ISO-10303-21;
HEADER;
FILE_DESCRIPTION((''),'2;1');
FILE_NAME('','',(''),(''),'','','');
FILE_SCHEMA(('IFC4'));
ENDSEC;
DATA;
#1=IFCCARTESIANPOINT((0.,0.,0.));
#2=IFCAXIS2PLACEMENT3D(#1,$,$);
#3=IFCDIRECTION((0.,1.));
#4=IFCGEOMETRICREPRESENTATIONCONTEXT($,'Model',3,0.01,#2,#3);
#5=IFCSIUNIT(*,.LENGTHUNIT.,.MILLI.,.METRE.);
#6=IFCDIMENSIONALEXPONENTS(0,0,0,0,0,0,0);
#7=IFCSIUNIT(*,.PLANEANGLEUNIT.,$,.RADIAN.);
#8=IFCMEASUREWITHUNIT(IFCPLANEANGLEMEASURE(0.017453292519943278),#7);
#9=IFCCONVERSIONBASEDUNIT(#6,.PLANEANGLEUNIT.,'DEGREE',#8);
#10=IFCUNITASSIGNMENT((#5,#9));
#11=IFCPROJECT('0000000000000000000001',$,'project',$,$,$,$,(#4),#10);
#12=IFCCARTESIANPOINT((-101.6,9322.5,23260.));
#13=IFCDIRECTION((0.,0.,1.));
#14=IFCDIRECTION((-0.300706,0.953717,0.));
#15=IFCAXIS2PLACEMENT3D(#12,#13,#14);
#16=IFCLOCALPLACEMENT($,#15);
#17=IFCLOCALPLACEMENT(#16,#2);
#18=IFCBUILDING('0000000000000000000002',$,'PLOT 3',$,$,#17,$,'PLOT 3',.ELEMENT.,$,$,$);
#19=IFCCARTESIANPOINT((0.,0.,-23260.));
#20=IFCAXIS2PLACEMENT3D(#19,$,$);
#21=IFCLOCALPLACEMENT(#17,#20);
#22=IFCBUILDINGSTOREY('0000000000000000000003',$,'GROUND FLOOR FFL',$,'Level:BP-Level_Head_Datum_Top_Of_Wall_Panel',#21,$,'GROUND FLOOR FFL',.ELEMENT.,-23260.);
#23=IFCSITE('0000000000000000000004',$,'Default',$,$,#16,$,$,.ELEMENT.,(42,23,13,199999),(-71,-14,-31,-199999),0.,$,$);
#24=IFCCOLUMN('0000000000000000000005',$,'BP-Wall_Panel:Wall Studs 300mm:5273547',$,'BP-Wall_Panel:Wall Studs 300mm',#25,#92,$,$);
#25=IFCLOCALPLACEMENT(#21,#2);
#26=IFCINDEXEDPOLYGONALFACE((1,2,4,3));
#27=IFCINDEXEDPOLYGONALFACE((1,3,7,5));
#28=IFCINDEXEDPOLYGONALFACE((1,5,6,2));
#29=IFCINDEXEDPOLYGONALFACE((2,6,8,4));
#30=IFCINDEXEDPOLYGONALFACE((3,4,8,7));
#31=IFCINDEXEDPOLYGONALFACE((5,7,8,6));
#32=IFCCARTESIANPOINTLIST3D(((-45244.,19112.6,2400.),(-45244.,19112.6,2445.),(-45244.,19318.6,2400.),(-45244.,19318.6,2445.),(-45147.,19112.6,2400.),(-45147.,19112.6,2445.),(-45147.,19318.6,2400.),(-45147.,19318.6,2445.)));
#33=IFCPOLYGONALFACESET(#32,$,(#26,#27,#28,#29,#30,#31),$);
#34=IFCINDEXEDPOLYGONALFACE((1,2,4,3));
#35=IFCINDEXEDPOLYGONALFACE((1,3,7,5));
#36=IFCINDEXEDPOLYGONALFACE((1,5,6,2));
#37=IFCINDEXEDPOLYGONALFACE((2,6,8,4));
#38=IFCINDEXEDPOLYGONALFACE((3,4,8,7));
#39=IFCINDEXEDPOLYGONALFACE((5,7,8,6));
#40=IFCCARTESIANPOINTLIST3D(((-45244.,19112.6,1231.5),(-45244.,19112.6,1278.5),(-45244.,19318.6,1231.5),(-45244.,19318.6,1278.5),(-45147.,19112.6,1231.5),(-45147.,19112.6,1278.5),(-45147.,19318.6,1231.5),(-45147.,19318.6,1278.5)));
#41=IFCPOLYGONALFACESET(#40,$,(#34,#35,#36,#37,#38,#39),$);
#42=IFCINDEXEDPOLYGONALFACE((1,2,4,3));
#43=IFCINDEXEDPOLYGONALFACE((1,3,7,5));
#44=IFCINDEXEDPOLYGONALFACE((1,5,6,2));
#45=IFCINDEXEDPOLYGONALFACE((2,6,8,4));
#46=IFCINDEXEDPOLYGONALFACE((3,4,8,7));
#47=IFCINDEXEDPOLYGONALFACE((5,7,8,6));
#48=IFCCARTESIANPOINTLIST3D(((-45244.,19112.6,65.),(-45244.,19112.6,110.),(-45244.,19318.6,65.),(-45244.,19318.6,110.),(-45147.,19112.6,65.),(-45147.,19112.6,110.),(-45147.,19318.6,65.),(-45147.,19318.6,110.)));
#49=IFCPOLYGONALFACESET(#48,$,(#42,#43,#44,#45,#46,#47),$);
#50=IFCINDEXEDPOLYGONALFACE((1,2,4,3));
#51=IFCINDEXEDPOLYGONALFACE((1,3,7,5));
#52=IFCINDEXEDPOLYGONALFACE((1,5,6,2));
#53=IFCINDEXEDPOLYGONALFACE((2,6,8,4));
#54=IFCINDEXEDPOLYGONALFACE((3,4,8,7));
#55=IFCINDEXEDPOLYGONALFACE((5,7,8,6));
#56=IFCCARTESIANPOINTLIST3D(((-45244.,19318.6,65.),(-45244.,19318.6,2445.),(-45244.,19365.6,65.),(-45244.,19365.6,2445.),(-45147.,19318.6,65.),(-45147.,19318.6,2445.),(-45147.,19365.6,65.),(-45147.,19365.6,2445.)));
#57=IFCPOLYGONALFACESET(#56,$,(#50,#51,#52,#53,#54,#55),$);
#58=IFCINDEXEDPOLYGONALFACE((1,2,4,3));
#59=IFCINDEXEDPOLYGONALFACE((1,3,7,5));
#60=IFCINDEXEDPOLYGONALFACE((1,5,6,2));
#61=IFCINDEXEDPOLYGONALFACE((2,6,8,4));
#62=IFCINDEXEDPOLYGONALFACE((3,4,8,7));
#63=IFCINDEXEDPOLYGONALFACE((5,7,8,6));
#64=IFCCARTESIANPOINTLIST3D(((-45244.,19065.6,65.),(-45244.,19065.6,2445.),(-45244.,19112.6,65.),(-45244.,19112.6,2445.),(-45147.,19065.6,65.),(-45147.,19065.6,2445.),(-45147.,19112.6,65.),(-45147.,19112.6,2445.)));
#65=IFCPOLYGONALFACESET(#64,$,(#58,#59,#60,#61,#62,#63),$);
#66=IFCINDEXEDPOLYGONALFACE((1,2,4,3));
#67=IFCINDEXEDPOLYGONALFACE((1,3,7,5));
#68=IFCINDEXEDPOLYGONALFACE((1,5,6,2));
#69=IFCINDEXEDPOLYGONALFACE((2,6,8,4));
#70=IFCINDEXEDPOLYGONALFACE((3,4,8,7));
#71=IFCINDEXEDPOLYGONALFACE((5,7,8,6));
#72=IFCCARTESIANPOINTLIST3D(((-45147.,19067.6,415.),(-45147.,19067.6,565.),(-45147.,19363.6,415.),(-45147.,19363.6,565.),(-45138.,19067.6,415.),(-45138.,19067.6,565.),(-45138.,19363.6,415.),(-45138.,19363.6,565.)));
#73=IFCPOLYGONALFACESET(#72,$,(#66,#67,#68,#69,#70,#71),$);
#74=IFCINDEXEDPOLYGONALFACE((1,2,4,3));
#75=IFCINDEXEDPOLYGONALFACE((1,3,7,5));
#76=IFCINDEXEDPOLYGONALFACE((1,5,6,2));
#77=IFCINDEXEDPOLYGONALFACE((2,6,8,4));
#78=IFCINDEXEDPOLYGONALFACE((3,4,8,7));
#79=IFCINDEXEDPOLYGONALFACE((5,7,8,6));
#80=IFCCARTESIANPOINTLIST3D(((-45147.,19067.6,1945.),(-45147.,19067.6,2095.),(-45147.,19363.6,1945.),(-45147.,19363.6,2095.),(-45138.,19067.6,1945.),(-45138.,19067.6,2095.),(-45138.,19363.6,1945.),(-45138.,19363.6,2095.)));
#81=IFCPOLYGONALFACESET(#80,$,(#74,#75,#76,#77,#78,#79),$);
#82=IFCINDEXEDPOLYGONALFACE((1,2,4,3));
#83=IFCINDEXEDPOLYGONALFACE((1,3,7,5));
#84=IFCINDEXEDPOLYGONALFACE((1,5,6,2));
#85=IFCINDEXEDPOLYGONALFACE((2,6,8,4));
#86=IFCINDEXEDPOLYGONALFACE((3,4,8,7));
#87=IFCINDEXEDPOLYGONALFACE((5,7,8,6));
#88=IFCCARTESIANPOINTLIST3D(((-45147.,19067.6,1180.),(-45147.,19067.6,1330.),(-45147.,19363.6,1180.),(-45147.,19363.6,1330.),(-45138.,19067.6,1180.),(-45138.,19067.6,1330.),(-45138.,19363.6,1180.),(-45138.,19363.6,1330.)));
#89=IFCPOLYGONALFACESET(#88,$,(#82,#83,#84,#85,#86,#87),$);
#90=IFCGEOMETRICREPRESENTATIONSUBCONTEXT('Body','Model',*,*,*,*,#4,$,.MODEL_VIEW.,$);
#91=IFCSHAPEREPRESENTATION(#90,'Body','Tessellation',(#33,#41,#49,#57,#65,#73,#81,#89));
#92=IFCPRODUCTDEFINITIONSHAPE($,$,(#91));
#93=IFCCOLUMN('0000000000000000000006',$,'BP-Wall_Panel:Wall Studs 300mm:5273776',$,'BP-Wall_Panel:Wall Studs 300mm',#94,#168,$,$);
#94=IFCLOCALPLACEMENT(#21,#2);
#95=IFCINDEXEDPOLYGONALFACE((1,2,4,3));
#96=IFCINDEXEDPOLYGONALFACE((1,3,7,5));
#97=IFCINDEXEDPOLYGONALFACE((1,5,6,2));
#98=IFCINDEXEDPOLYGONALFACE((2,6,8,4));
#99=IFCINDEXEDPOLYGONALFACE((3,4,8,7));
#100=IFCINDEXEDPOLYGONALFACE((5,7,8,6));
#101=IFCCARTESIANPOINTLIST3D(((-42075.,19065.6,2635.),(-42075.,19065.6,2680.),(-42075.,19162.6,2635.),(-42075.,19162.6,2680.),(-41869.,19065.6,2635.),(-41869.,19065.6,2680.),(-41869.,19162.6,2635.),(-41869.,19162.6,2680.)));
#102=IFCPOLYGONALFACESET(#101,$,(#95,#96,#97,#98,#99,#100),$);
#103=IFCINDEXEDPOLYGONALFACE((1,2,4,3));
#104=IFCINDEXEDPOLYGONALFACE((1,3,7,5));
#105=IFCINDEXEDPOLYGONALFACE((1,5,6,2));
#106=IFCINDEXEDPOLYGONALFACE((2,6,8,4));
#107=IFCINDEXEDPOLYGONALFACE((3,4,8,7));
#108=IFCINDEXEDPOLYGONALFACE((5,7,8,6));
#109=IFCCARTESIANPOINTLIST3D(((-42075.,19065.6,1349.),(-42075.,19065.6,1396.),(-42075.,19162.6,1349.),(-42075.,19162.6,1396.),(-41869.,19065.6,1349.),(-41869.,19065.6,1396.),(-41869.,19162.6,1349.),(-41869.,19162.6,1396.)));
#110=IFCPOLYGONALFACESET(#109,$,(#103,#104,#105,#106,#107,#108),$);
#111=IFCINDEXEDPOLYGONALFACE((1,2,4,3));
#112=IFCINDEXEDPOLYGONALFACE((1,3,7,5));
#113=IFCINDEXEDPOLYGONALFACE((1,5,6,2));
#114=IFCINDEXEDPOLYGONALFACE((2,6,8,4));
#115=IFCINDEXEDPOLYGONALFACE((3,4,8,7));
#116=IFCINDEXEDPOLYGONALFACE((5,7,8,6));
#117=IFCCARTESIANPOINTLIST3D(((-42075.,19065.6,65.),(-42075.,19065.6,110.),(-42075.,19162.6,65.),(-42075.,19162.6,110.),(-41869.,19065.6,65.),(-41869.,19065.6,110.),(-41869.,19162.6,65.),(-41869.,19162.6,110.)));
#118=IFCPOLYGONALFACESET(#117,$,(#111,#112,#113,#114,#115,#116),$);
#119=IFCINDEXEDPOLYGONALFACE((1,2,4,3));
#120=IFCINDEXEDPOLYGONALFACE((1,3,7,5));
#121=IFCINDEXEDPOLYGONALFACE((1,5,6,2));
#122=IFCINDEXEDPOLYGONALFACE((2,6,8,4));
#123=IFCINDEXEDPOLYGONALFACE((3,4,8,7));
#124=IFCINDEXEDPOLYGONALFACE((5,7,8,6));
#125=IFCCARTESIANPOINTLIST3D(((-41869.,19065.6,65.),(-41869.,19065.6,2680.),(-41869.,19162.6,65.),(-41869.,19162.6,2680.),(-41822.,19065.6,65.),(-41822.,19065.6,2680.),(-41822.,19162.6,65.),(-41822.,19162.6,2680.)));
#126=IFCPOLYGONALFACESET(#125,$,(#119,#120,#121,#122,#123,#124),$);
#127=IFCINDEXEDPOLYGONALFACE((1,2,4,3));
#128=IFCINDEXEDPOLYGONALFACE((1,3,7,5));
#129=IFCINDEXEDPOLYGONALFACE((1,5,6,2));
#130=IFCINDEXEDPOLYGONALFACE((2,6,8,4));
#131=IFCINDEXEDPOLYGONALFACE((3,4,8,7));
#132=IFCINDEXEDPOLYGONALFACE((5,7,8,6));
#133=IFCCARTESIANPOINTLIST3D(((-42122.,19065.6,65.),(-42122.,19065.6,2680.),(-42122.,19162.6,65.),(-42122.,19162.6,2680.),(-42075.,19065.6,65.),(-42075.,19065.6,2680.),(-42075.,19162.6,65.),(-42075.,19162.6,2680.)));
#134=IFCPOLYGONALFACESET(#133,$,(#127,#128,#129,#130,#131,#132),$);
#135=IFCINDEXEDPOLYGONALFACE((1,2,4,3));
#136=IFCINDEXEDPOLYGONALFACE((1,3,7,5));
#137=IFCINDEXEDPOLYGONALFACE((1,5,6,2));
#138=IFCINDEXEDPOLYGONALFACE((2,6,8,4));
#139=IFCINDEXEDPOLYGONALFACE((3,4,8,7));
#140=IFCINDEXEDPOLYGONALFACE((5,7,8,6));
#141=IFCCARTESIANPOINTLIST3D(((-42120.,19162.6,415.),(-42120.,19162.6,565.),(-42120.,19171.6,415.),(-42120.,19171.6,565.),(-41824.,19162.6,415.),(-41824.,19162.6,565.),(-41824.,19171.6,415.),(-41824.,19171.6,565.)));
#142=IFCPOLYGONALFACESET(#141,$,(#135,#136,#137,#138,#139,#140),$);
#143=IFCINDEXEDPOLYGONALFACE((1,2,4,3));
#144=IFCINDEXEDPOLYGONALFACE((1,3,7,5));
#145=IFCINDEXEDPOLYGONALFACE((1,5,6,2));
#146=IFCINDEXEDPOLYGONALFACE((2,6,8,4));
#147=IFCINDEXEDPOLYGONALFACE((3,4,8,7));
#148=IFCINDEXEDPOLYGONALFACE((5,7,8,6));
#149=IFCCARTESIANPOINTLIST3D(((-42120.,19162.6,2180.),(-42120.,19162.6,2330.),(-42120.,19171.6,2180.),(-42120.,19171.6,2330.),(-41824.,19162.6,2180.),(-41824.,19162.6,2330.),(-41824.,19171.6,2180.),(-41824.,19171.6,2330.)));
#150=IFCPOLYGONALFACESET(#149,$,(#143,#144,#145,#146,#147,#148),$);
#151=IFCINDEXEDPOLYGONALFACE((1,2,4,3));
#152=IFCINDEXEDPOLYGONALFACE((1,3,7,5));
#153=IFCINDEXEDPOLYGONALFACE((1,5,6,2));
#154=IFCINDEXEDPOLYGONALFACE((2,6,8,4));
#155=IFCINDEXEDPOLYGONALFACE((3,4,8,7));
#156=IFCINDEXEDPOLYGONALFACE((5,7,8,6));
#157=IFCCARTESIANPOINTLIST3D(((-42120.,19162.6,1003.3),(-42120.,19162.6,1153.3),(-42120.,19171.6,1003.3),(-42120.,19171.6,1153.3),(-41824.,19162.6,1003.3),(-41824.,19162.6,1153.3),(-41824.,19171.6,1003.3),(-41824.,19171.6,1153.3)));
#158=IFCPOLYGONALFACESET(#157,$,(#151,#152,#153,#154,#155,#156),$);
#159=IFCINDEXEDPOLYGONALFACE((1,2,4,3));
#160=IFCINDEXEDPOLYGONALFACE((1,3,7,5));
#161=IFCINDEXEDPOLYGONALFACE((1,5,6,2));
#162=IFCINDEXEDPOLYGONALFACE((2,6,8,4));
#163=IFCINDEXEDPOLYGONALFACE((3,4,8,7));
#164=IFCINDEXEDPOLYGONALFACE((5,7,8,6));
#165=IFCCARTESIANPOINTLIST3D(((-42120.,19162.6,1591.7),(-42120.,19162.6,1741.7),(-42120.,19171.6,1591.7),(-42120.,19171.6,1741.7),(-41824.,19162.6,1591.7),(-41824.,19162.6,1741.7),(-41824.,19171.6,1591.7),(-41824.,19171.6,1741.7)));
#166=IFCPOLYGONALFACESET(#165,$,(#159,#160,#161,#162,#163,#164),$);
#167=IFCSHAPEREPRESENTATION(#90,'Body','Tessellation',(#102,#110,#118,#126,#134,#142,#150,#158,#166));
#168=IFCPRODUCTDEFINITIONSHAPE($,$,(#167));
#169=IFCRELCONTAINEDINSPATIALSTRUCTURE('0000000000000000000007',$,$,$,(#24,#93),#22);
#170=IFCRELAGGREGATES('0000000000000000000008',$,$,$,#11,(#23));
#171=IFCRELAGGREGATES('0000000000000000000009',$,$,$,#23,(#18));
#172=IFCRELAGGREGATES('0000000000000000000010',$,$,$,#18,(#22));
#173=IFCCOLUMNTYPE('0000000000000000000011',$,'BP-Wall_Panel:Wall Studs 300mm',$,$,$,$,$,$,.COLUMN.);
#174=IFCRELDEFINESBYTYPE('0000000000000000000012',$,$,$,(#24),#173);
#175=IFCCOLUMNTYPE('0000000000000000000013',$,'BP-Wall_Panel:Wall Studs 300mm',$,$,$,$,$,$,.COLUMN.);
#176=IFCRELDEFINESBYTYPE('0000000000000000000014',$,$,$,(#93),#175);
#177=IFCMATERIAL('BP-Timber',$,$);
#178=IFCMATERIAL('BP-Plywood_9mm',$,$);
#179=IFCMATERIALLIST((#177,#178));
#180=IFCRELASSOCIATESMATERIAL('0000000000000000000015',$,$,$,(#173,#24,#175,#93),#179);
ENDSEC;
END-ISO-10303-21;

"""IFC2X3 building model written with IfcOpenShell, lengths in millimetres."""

from ifc_helpers import new_model, entity, si_unit, converted_unit, direction, frame, frame_2d, origin, place, context, subcontext, project, spatial, rectangle, extrude, source, transform, mapped, material, material_list, type_object, type_shapes, element, save


model = new_model("IFC2X3")

# Units and contexts
model_context = context("Model", 3, precision=0.01, world=origin(), true_north=direction((0.0, 1.0)))
body_context = subcontext(model_context, "Body", "Model", "MODEL_VIEW")
ifc_project = project(units=[si_unit("LENGTHUNIT", "METRE", prefix="MILLI"), converted_unit("PLANEANGLEUNIT", "DEGREE", entity("IfcPlaneAngleMeasure", 0.017453292519943278), si_unit("PLANEANGLEUNIT", "RADIAN"), dimensions=[0, 0, 0, 0, 0, 0, 0])], contexts=[model_context])

# Site, building, storey
site_placement = place(None, frame((-101.6, 9322.5, 23260.0), z_axis=(0.0, 0.0, 1.0), x_axis=(-0.300706, 0.953717, 0.0)))
site = spatial("IfcSite", under=ifc_project, at=site_placement, Name="Default", CompositionType="ELEMENT", RefLatitude=(42, 23, 13, 199999), RefLongitude=(-71, -14, -31, -199999), RefElevation=0.0)
building_placement = place(site_placement, origin())
building = spatial("IfcBuilding", under=site, at=building_placement, Name="PLOT 3", LongName="PLOT 3", CompositionType="ELEMENT")
storey_placement = place(building_placement, frame((0.0, 0.0, -23260.0)))
storey = spatial("IfcBuildingStorey", under=building, at=storey_placement, Name="GROUND FLOOR FFL", ObjectType="Level:BP-Level_Head_Datum_Top_Of_Wall_Panel", LongName="GROUND FLOOR FFL", CompositionType="ELEMENT", Elevation=-23260.0)

# Columns
ifc_material_1 = material(Name="BP-Timber")
ifc_material_2 = material(Name="BP-Plywood_9mm")
ifc_material_list_1 = material_list([ifc_material_1, ifc_material_2])
column_type_1 = type_object("IfcColumnType", Name="BP-Wall_Panel:Wall Studs 300mm", PredefinedType="COLUMN", material=ifc_material_list_1)
shared_shape_1 = source(origin(), body_context, "Body", "SweptSolid", [
    extrude(rectangle(XDim=206.0, YDim=97.0, at=frame_2d((0.0, 0.0), x_axis=(1.0, 0.0))), frame((-45195.5, 19215.6, -20860.0), z_axis=(0.0, 0.0, 1.0), x_axis=(0.0, -1.0, 0.0)), (0.0, 0.0, 1.0), 45.0),
    extrude(rectangle(XDim=206.0, YDim=97.0, at=frame_2d((0.0, 0.0), x_axis=(1.0, 0.0))), frame((-45195.5, 19215.6, -22028.5), z_axis=(0.0, 0.0, 1.0), x_axis=(0.0, -1.0, 0.0)), (0.0, 0.0, 1.0), 47.0),
    extrude(rectangle(XDim=206.0, YDim=97.0, at=frame_2d((0.0, 0.0), x_axis=(1.0, 0.0))), frame((-45195.5, 19215.6, -23195.0), z_axis=(0.0, 0.0, 1.0), x_axis=(0.0, -1.0, 0.0)), (0.0, 0.0, 1.0), 45.0),
    extrude(rectangle(XDim=97.0, YDim=47.0, at=frame_2d((0.0, 0.0), x_axis=(1.0, 0.0))), frame((-45195.5, 19342.1, -23195.0), z_axis=(0.0, 0.0, 1.0), x_axis=(-1.0, 0.0, 0.0)), (0.0, 0.0, 1.0), 2380.0),
    extrude(rectangle(XDim=97.0, YDim=47.0, at=frame_2d((0.0, 0.0), x_axis=(1.0, 0.0))), frame((-45195.5, 19089.1, -23195.0), z_axis=(0.0, 0.0, 1.0), x_axis=(-1.0, 0.0, 0.0)), (0.0, 0.0, 1.0), 2380.0),
    extrude(rectangle(XDim=296.0, YDim=9.0, at=frame_2d((0.0, 0.0), x_axis=(1.0, 0.0))), frame((-45142.5, 19215.6, -22845.0), z_axis=(0.0, 0.0, 1.0), x_axis=(0.0, -1.0, 0.0)), (0.0, 0.0, 1.0), 150.0),
    extrude(rectangle(XDim=296.0, YDim=9.0, at=frame_2d((0.0, 0.0), x_axis=(1.0, 0.0))), frame((-45142.5, 19215.6, -21315.0), z_axis=(0.0, 0.0, 1.0), x_axis=(0.0, -1.0, 0.0)), (0.0, 0.0, 1.0), 150.0),
    extrude(rectangle(XDim=296.0, YDim=9.0, at=frame_2d((0.0, 0.0), x_axis=(1.0, 0.0))), frame((-45142.5, 19215.6, -22080.0), z_axis=(0.0, 0.0, 1.0), x_axis=(0.0, -1.0, 0.0)), (0.0, 0.0, 1.0), 150.0),
])
type_shapes(column_type_1, [shared_shape_1])
column_1_placement = place(storey_placement, frame((0.0, 0.0, 23260.0)))
element("IfcColumn", 1, at=column_1_placement, inside=storey, type_object=column_type_1, material=ifc_material_list_1, Name="BP-Wall_Panel:Wall Studs 300mm:5273547", ObjectType="BP-Wall_Panel:Wall Studs 300mm", context=body_context, shape_type="MappedRepresentation", body=[
    mapped(shared_shape_1, transform((0.0, 0.0, 0.0), scale=1.0)),
])
column_type_2 = type_object("IfcColumnType", Name="BP-Wall_Panel:Wall Studs 300mm", PredefinedType="COLUMN", material=ifc_material_list_1)
shared_shape_2 = source(origin(), body_context, "Body", "SweptSolid", [
    extrude(rectangle(XDim=97.0, YDim=206.0, at=frame_2d((0.0, 0.0), x_axis=(1.0, 0.0))), frame((-41972.0, 19114.1, -20625.0), z_axis=(0.0, 0.0, 1.0), x_axis=(0.0, 1.0, 0.0)), (0.0, 0.0, 1.0), 45.0),
    extrude(rectangle(XDim=97.0, YDim=206.0, at=frame_2d((0.0, 0.0), x_axis=(1.0, 0.0))), frame((-41972.0, 19114.1, -21911.0), z_axis=(0.0, 0.0, 1.0), x_axis=(0.0, 1.0, 0.0)), (0.0, 0.0, 1.0), 47.0),
    extrude(rectangle(XDim=97.0, YDim=206.0, at=frame_2d((0.0, 0.0), x_axis=(1.0, 0.0))), frame((-41972.0, 19114.1, -23195.0), z_axis=(0.0, 0.0, 1.0), x_axis=(0.0, 1.0, 0.0)), (0.0, 0.0, 1.0), 45.0),
    extrude(rectangle(XDim=47.0, YDim=97.0, at=frame_2d((0.0, 0.0), x_axis=(1.0, 0.0))), frame((-41845.5, 19114.1, -23195.0), z_axis=(0.0, 0.0, 1.0), x_axis=(-1.0, 0.0, 0.0)), (0.0, 0.0, 1.0), 2615.0),
    extrude(rectangle(XDim=47.0, YDim=97.0, at=frame_2d((0.0, 0.0), x_axis=(1.0, 0.0))), frame((-42098.5, 19114.1, -23195.0), z_axis=(0.0, 0.0, 1.0), x_axis=(-1.0, 0.0, 0.0)), (0.0, 0.0, 1.0), 2615.0),
    extrude(rectangle(XDim=9.0, YDim=296.0, at=frame_2d((0.0, 0.0), x_axis=(1.0, 0.0))), frame((-41972.0, 19167.1, -22845.0), z_axis=(0.0, 0.0, 1.0), x_axis=(0.0, 1.0, 0.0)), (0.0, 0.0, 1.0), 150.0),
    extrude(rectangle(XDim=9.0, YDim=296.0, at=frame_2d((0.0, 0.0), x_axis=(1.0, 0.0))), frame((-41972.0, 19167.1, -21080.0), z_axis=(0.0, 0.0, 1.0), x_axis=(0.0, 1.0, 0.0)), (0.0, 0.0, 1.0), 150.0),
    extrude(rectangle(XDim=9.0, YDim=296.0, at=frame_2d((0.0, 0.0), x_axis=(1.0, 0.0))), frame((-41972.0, 19167.1, -22256.7), z_axis=(0.0, 0.0, 1.0), x_axis=(0.0, 1.0, 0.0)), (0.0, 0.0, 1.0), 150.0),
    extrude(rectangle(XDim=9.0, YDim=296.0, at=frame_2d((0.0, 0.0), x_axis=(1.0, 0.0))), frame((-41972.0, 19167.1, -21668.3), z_axis=(0.0, 0.0, 1.0), x_axis=(0.0, 1.0, 0.0)), (0.0, 0.0, 1.0), 150.0),
])
type_shapes(column_type_2, [shared_shape_2])
column_2_placement = place(storey_placement, frame((0.0, 0.0, 23260.0)))
element("IfcColumn", 2, at=column_2_placement, inside=storey, type_object=column_type_2, material=ifc_material_list_1, Name="BP-Wall_Panel:Wall Studs 300mm:5273776", ObjectType="BP-Wall_Panel:Wall Studs 300mm", context=body_context, shape_type="MappedRepresentation", body=[
    mapped(shared_shape_2, transform((0.0, 0.0, 0.0), scale=1.0)),
])

save(model, "model.ifc")
